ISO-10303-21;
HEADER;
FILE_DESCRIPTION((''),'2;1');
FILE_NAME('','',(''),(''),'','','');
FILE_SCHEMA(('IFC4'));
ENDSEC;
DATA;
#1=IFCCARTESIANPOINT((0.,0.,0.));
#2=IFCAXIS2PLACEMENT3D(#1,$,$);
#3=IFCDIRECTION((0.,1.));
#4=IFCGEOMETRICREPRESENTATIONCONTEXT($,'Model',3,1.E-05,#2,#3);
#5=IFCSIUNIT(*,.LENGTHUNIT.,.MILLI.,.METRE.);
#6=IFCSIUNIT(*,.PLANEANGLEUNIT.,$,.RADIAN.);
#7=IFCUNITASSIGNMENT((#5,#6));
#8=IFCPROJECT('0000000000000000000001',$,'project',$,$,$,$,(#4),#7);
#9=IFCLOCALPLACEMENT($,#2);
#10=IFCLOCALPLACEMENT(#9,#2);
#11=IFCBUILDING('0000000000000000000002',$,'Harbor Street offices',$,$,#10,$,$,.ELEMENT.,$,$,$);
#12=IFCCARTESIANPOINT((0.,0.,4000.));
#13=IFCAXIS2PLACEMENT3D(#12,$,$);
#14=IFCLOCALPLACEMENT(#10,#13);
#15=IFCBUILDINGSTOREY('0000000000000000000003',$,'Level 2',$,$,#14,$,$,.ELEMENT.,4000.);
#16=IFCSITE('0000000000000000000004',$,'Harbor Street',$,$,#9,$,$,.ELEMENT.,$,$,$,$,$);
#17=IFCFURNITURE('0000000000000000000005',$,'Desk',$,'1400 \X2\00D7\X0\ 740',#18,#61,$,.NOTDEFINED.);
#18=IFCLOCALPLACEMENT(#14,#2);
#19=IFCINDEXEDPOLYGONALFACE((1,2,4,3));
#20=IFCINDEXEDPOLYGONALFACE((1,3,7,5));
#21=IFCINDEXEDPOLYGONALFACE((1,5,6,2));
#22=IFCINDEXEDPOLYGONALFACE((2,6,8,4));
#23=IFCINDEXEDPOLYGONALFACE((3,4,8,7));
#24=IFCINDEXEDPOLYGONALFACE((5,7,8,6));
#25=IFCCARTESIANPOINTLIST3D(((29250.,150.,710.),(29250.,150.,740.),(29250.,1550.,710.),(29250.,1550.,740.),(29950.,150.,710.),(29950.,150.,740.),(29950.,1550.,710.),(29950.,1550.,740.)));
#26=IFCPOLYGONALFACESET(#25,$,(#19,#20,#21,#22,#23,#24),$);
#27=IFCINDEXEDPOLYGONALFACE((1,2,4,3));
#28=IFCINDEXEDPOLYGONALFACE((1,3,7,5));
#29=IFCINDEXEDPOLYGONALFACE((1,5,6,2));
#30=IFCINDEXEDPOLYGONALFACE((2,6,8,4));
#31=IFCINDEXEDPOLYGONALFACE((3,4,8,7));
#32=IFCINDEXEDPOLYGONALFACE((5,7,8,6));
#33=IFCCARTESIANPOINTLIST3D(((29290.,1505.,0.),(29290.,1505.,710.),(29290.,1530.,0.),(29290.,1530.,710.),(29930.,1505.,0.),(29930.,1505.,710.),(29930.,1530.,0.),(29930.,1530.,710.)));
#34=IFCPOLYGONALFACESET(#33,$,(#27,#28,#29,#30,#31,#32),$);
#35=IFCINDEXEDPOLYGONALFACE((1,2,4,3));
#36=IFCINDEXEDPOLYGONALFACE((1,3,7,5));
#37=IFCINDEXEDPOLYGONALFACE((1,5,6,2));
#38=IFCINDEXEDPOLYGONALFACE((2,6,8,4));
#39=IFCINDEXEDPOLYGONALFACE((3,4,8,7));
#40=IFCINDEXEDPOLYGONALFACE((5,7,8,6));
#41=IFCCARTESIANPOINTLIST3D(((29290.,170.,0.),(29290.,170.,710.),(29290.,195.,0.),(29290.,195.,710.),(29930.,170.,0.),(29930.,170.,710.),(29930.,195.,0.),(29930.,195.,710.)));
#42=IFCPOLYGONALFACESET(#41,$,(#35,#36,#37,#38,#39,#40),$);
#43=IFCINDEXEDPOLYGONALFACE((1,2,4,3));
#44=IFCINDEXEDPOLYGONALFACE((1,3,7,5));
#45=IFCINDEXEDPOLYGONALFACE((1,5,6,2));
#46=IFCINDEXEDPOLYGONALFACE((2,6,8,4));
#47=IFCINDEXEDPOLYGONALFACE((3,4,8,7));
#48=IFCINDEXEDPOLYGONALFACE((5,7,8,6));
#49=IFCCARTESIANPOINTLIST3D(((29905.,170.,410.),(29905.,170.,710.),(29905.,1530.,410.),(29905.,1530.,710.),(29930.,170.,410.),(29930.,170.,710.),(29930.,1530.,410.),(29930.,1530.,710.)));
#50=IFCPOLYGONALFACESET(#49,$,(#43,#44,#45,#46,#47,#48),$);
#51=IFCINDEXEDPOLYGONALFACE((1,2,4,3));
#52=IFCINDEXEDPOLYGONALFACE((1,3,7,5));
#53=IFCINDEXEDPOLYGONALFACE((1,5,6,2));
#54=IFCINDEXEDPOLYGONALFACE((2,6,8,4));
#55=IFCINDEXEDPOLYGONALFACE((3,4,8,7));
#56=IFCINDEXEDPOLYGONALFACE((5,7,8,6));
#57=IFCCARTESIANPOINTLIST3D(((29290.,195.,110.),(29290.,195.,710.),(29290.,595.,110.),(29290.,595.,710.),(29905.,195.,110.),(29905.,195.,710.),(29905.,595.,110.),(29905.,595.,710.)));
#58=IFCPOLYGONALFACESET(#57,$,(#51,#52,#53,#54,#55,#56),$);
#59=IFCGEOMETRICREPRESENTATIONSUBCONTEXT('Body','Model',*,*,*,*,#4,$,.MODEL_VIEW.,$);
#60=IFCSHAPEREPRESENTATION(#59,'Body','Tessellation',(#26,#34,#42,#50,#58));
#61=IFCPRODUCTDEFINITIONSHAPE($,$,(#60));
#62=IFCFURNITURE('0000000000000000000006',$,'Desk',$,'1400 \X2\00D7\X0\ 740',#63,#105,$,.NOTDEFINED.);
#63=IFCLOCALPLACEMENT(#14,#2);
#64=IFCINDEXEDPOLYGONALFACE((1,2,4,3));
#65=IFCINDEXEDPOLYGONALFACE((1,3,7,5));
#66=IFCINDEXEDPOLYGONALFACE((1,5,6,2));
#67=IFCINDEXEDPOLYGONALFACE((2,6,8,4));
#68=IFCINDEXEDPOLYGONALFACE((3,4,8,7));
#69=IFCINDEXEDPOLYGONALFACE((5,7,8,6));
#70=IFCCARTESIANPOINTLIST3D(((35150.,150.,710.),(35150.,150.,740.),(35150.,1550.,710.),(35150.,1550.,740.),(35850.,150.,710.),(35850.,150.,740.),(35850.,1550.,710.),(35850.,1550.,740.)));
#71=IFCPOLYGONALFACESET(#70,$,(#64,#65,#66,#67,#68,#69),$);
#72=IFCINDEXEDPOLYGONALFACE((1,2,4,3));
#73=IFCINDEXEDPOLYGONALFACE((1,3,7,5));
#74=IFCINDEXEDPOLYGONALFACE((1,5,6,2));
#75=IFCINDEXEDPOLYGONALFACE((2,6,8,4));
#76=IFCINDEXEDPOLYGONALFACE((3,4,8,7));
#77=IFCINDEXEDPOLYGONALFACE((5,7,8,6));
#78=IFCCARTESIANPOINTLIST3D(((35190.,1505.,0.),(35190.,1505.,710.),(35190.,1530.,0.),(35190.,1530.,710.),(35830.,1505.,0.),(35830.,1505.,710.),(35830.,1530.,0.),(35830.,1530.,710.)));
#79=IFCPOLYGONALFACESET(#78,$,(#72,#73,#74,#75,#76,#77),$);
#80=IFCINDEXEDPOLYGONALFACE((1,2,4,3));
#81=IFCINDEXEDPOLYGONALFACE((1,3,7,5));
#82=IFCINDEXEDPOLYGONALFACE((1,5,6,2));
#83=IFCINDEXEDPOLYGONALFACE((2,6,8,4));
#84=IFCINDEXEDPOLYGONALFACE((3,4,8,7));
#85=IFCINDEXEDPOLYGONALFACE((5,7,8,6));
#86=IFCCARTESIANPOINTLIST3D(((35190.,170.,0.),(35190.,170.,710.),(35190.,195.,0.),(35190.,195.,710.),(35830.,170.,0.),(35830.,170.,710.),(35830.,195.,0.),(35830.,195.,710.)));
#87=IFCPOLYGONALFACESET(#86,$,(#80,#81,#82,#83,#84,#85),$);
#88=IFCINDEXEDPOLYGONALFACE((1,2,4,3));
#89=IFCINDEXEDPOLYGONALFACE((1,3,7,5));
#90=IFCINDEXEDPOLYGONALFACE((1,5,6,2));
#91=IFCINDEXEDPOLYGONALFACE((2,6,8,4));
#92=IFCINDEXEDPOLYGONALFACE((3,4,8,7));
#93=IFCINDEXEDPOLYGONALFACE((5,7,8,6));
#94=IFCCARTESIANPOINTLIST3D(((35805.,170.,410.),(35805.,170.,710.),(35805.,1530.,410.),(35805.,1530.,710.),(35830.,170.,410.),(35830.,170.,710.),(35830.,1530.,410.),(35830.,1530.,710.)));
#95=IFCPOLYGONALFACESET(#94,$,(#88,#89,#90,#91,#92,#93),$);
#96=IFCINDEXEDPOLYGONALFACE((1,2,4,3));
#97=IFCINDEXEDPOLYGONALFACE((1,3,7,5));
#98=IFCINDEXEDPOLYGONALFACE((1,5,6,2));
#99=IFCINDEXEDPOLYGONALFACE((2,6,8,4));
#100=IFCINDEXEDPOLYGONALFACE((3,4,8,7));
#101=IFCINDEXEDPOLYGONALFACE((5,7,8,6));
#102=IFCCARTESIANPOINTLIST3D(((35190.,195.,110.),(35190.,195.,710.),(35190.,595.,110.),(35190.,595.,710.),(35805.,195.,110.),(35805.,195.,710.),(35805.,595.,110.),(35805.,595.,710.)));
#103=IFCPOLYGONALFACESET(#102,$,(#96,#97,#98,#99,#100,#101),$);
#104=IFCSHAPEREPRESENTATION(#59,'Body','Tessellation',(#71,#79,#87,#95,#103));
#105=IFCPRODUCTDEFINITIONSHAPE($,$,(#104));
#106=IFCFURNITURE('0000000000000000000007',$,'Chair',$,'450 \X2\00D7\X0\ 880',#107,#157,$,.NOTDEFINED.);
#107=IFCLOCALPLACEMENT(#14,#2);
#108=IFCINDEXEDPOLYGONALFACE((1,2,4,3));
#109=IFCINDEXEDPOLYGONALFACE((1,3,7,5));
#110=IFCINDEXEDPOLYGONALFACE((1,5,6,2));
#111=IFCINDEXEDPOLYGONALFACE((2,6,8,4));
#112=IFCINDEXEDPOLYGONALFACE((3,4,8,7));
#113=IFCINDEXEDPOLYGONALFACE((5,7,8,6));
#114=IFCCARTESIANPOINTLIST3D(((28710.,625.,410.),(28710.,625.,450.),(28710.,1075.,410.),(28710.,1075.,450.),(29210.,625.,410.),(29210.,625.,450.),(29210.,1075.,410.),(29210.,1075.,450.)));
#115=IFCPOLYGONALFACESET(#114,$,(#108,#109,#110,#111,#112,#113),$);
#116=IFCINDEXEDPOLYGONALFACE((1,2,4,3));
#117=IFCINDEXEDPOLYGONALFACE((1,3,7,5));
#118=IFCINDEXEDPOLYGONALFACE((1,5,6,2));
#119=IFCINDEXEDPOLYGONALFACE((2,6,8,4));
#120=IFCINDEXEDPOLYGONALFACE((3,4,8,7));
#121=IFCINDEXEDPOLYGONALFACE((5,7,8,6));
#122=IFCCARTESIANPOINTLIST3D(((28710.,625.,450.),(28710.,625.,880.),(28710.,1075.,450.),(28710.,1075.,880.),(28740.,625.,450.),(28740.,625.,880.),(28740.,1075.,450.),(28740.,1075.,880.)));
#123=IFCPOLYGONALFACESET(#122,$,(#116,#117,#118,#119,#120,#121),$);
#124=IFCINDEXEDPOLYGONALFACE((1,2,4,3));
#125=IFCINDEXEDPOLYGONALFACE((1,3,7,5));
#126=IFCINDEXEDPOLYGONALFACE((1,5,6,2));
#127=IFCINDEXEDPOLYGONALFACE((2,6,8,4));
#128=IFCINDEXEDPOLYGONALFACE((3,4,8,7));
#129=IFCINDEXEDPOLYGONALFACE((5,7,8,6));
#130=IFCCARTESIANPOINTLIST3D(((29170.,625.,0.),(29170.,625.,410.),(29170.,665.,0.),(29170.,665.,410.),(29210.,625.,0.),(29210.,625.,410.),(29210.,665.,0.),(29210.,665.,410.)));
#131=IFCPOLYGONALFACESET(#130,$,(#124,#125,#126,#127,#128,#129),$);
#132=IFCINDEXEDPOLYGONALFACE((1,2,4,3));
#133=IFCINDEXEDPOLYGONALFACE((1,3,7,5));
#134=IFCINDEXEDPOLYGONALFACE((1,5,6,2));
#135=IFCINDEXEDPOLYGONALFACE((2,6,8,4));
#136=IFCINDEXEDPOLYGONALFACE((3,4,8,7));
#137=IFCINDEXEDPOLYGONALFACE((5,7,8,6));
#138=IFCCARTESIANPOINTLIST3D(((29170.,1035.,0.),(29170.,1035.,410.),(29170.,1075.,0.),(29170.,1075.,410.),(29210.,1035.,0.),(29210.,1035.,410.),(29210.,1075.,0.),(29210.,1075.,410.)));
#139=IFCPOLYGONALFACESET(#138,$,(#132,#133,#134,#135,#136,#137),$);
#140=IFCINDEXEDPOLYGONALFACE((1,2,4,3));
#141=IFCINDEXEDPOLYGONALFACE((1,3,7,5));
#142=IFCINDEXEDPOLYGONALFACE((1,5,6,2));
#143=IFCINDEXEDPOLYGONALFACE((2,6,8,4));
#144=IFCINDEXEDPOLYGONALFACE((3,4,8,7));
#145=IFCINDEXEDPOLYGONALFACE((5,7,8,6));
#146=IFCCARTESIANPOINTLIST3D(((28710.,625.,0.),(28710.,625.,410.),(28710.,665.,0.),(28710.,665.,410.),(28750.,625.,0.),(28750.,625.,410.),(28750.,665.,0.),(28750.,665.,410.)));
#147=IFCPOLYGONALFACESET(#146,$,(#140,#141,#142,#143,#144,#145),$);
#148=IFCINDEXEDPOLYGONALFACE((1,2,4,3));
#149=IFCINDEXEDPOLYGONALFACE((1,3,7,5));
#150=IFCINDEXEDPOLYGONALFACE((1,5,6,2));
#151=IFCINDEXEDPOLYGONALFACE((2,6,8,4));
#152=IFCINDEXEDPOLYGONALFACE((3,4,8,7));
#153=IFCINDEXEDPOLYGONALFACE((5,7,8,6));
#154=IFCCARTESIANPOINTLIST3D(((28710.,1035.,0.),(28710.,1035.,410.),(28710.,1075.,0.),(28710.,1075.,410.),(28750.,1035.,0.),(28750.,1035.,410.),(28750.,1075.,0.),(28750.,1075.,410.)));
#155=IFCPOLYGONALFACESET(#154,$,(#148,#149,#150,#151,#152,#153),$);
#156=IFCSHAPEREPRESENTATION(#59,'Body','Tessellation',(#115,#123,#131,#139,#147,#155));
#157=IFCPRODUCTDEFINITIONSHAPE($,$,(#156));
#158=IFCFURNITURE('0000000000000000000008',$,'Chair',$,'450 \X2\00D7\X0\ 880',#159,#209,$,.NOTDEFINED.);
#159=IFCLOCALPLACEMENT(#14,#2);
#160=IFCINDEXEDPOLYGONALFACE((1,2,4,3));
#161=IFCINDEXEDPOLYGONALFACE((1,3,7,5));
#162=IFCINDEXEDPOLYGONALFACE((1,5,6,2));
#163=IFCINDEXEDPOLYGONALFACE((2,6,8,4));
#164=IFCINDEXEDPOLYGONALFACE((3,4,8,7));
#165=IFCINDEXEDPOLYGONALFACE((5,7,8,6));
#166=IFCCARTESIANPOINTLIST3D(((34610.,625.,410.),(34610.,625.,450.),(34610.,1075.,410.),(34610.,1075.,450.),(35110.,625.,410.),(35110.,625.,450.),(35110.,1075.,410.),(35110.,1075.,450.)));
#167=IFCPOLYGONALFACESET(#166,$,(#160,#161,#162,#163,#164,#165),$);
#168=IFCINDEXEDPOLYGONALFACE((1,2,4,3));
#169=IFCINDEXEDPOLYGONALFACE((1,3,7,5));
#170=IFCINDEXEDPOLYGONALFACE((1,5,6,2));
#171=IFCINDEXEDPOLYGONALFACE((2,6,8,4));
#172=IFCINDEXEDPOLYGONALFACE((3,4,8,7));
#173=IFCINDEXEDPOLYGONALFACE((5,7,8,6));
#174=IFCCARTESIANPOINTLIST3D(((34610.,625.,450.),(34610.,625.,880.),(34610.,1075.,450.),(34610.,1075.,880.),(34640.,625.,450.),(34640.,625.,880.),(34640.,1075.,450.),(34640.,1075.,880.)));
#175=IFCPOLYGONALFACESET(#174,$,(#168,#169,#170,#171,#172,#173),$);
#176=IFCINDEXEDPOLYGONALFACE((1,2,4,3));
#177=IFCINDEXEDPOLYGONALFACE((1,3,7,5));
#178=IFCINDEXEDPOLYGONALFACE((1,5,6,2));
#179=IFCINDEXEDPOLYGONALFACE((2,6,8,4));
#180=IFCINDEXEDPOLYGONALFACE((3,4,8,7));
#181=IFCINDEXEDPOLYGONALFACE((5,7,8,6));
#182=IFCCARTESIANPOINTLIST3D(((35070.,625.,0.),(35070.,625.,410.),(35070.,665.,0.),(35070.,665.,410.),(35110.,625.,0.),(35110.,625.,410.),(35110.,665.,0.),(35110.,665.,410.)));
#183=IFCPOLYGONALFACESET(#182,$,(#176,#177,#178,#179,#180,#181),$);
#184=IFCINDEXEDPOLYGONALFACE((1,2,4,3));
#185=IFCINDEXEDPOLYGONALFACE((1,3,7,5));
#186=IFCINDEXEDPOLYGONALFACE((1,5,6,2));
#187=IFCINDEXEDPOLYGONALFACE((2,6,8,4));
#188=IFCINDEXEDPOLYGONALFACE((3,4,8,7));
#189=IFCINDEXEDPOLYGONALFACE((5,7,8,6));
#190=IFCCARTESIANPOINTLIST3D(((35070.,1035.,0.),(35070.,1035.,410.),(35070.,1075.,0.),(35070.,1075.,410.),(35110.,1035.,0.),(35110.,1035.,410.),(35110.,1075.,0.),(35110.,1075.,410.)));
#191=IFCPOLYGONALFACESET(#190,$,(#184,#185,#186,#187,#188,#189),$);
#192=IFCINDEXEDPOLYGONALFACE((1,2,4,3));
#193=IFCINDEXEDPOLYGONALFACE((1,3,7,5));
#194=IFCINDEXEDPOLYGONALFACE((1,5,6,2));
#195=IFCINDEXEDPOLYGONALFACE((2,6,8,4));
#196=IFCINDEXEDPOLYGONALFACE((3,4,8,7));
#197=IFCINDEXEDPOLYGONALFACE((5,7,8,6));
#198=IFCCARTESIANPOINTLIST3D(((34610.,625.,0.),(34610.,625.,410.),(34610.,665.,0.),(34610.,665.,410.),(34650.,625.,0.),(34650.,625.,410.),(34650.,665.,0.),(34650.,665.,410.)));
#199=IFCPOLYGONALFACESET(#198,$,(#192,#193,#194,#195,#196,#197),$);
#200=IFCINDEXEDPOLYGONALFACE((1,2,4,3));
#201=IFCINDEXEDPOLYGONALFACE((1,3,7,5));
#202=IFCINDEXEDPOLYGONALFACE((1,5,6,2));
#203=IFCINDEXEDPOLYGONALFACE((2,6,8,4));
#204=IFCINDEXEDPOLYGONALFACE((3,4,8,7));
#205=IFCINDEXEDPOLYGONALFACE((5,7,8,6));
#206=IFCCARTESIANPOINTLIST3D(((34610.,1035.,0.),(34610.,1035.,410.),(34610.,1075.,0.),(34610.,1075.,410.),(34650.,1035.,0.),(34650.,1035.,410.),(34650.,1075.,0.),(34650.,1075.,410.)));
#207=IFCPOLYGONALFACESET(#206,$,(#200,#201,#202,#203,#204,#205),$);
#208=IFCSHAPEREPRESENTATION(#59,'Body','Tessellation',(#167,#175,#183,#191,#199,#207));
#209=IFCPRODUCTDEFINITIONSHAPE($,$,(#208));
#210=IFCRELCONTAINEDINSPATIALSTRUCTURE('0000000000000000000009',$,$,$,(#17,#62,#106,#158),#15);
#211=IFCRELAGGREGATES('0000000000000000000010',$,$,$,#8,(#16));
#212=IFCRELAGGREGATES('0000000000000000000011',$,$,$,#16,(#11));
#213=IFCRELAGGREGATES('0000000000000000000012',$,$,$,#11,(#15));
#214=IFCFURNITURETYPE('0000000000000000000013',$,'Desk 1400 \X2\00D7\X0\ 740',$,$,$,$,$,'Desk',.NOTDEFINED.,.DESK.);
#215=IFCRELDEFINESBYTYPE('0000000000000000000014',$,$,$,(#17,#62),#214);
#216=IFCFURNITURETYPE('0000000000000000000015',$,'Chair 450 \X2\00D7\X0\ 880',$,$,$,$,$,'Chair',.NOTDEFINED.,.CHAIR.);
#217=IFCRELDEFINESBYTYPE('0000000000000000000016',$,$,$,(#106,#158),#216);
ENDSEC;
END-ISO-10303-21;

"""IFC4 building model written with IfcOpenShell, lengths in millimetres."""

from ifc_helpers import new_model, si_unit, direction, frame, origin, place, context, subcontext, project, spatial, polyline, outline, extrude, source, transform, mapped, type_object, type_shapes, element, save


model = new_model("IFC4")

# Units and contexts
model_context = context("Model", 3, precision=1e-05, world=origin(), true_north=direction((0.0, 1.0)))
body_context = subcontext(model_context, "Body", "Model", "MODEL_VIEW")
ifc_project = project(units=[si_unit("LENGTHUNIT", "METRE", prefix="MILLI"), si_unit("PLANEANGLEUNIT", "RADIAN")], contexts=[model_context])

# Site, building, storey
site_placement = place(None, origin())
site = spatial("IfcSite", under=ifc_project, at=site_placement, Name="Harbor Street", CompositionType="ELEMENT")
building_placement = place(site_placement, origin())
building = spatial("IfcBuilding", under=site, at=building_placement, Name="Harbor Street offices", CompositionType="ELEMENT")
storey_placement = place(building_placement, frame((0.0, 0.0, 4000.0)))
storey = spatial("IfcBuildingStorey", under=building, at=storey_placement, Name="Level 2", CompositionType="ELEMENT", Elevation=4000.0)

# Furniture
furniture_type_1 = type_object("IfcFurnitureType", Name="Desk 1400 × 740", ElementType="Desk", AssemblyPlace="NOTDEFINED", PredefinedType="DESK")
shared_shape_1 = source(origin(), body_context, "Body", "SweptSolid", [
    extrude(outline(polyline([(-700.0, 0.0), (700.0, 0.0), (700.0, 700.0), (-700.0, 700.0), (-700.0, 0.0)])), frame((0.0, 0.0, 710.0)), (0.0, 0.0, 1.0), 30.0),
    extrude(outline(polyline([(-680.0, 40.0), (-655.0, 40.0), (-655.0, 680.0), (-680.0, 680.0), (-680.0, 40.0)])), origin(), (0.0, 0.0, 1.0), 710.0),
    extrude(outline(polyline([(655.0, 40.0), (680.0, 40.0), (680.0, 680.0), (655.0, 680.0), (655.0, 40.0)])), origin(), (0.0, 0.0, 1.0), 710.0),
    extrude(outline(polyline([(-680.0, 655.0), (680.0, 655.0), (680.0, 680.0), (-680.0, 680.0), (-680.0, 655.0)])), frame((0.0, 0.0, 410.0)), (0.0, 0.0, 1.0), 300.0),
    extrude(outline(polyline([(255.0, 40.0), (655.0, 40.0), (655.0, 655.0), (255.0, 655.0), (255.0, 40.0)])), frame((0.0, 0.0, 110.0)), (0.0, 0.0, 1.0), 600.0),
])
type_shapes(furniture_type_1, [shared_shape_1])
for number, where, z_axis, x_axis, name in (
    (1, (29250.0, 850.0, 0.0), (0.0, 0.0, 1.0), (0.0, -1.0, 0.0), "Desk"),
    (2, (35150.0, 850.0, 0.0), (0.0, 0.0, 1.0), (0.0, -1.0, 0.0), "Desk"),
):
    element("IfcFurniture", number, at=place(storey_placement, frame(where, z_axis=z_axis, x_axis=x_axis)), inside=storey, type_object=furniture_type_1, Name=name, ObjectType="1400 × 740", PredefinedType="NOTDEFINED", context=body_context, shape_type="MappedRepresentation", body=[
        mapped(shared_shape_1, transform((0.0, 0.0, 0.0))),
    ])
furniture_type_2 = type_object("IfcFurnitureType", Name="Chair 450 × 880", ElementType="Chair", AssemblyPlace="NOTDEFINED", PredefinedType="CHAIR")
shared_shape_2 = source(origin(), body_context, "Body", "SweptSolid", [
    extrude(outline(polyline([(-225.0, 0.0), (225.0, 0.0), (225.0, 500.0), (-225.0, 500.0), (-225.0, 0.0)])), frame((0.0, 0.0, 410.0)), (0.0, 0.0, 1.0), 40.0),
    extrude(outline(polyline([(-225.0, 470.0), (225.0, 470.0), (225.0, 500.0), (-225.0, 500.0), (-225.0, 470.0)])), frame((0.0, 0.0, 450.0)), (0.0, 0.0, 1.0), 430.0),
    extrude(outline(polyline([(-225.0, 0.0), (-185.0, 0.0), (-185.0, 40.0), (-225.0, 40.0), (-225.0, 0.0)])), origin(), (0.0, 0.0, 1.0), 410.0),
    extrude(outline(polyline([(185.0, 0.0), (225.0, 0.0), (225.0, 40.0), (185.0, 40.0), (185.0, 0.0)])), origin(), (0.0, 0.0, 1.0), 410.0),
    extrude(outline(polyline([(-225.0, 460.0), (-185.0, 460.0), (-185.0, 500.0), (-225.0, 500.0), (-225.0, 460.0)])), origin(), (0.0, 0.0, 1.0), 410.0),
    extrude(outline(polyline([(185.0, 460.0), (225.0, 460.0), (225.0, 500.0), (185.0, 500.0), (185.0, 460.0)])), origin(), (0.0, 0.0, 1.0), 410.0),
])
type_shapes(furniture_type_2, [shared_shape_2])
for number, where, z_axis, x_axis, name in (
    (3, (29210.0, 850.0, 0.0), (0.0, 0.0, 1.0), (0.0, 1.0, 0.0), "Chair"),
    (4, (35110.0, 850.0, 0.0), (0.0, 0.0, 1.0), (0.0, 1.0, 0.0), "Chair"),
):
    element("IfcFurniture", number, at=place(storey_placement, frame(where, z_axis=z_axis, x_axis=x_axis)), inside=storey, type_object=furniture_type_2, Name=name, ObjectType="450 × 880", PredefinedType="NOTDEFINED", context=body_context, shape_type="MappedRepresentation", body=[
        mapped(shared_shape_2, transform((0.0, 0.0, 0.0))),
    ])

save(model, "model.ifc")
